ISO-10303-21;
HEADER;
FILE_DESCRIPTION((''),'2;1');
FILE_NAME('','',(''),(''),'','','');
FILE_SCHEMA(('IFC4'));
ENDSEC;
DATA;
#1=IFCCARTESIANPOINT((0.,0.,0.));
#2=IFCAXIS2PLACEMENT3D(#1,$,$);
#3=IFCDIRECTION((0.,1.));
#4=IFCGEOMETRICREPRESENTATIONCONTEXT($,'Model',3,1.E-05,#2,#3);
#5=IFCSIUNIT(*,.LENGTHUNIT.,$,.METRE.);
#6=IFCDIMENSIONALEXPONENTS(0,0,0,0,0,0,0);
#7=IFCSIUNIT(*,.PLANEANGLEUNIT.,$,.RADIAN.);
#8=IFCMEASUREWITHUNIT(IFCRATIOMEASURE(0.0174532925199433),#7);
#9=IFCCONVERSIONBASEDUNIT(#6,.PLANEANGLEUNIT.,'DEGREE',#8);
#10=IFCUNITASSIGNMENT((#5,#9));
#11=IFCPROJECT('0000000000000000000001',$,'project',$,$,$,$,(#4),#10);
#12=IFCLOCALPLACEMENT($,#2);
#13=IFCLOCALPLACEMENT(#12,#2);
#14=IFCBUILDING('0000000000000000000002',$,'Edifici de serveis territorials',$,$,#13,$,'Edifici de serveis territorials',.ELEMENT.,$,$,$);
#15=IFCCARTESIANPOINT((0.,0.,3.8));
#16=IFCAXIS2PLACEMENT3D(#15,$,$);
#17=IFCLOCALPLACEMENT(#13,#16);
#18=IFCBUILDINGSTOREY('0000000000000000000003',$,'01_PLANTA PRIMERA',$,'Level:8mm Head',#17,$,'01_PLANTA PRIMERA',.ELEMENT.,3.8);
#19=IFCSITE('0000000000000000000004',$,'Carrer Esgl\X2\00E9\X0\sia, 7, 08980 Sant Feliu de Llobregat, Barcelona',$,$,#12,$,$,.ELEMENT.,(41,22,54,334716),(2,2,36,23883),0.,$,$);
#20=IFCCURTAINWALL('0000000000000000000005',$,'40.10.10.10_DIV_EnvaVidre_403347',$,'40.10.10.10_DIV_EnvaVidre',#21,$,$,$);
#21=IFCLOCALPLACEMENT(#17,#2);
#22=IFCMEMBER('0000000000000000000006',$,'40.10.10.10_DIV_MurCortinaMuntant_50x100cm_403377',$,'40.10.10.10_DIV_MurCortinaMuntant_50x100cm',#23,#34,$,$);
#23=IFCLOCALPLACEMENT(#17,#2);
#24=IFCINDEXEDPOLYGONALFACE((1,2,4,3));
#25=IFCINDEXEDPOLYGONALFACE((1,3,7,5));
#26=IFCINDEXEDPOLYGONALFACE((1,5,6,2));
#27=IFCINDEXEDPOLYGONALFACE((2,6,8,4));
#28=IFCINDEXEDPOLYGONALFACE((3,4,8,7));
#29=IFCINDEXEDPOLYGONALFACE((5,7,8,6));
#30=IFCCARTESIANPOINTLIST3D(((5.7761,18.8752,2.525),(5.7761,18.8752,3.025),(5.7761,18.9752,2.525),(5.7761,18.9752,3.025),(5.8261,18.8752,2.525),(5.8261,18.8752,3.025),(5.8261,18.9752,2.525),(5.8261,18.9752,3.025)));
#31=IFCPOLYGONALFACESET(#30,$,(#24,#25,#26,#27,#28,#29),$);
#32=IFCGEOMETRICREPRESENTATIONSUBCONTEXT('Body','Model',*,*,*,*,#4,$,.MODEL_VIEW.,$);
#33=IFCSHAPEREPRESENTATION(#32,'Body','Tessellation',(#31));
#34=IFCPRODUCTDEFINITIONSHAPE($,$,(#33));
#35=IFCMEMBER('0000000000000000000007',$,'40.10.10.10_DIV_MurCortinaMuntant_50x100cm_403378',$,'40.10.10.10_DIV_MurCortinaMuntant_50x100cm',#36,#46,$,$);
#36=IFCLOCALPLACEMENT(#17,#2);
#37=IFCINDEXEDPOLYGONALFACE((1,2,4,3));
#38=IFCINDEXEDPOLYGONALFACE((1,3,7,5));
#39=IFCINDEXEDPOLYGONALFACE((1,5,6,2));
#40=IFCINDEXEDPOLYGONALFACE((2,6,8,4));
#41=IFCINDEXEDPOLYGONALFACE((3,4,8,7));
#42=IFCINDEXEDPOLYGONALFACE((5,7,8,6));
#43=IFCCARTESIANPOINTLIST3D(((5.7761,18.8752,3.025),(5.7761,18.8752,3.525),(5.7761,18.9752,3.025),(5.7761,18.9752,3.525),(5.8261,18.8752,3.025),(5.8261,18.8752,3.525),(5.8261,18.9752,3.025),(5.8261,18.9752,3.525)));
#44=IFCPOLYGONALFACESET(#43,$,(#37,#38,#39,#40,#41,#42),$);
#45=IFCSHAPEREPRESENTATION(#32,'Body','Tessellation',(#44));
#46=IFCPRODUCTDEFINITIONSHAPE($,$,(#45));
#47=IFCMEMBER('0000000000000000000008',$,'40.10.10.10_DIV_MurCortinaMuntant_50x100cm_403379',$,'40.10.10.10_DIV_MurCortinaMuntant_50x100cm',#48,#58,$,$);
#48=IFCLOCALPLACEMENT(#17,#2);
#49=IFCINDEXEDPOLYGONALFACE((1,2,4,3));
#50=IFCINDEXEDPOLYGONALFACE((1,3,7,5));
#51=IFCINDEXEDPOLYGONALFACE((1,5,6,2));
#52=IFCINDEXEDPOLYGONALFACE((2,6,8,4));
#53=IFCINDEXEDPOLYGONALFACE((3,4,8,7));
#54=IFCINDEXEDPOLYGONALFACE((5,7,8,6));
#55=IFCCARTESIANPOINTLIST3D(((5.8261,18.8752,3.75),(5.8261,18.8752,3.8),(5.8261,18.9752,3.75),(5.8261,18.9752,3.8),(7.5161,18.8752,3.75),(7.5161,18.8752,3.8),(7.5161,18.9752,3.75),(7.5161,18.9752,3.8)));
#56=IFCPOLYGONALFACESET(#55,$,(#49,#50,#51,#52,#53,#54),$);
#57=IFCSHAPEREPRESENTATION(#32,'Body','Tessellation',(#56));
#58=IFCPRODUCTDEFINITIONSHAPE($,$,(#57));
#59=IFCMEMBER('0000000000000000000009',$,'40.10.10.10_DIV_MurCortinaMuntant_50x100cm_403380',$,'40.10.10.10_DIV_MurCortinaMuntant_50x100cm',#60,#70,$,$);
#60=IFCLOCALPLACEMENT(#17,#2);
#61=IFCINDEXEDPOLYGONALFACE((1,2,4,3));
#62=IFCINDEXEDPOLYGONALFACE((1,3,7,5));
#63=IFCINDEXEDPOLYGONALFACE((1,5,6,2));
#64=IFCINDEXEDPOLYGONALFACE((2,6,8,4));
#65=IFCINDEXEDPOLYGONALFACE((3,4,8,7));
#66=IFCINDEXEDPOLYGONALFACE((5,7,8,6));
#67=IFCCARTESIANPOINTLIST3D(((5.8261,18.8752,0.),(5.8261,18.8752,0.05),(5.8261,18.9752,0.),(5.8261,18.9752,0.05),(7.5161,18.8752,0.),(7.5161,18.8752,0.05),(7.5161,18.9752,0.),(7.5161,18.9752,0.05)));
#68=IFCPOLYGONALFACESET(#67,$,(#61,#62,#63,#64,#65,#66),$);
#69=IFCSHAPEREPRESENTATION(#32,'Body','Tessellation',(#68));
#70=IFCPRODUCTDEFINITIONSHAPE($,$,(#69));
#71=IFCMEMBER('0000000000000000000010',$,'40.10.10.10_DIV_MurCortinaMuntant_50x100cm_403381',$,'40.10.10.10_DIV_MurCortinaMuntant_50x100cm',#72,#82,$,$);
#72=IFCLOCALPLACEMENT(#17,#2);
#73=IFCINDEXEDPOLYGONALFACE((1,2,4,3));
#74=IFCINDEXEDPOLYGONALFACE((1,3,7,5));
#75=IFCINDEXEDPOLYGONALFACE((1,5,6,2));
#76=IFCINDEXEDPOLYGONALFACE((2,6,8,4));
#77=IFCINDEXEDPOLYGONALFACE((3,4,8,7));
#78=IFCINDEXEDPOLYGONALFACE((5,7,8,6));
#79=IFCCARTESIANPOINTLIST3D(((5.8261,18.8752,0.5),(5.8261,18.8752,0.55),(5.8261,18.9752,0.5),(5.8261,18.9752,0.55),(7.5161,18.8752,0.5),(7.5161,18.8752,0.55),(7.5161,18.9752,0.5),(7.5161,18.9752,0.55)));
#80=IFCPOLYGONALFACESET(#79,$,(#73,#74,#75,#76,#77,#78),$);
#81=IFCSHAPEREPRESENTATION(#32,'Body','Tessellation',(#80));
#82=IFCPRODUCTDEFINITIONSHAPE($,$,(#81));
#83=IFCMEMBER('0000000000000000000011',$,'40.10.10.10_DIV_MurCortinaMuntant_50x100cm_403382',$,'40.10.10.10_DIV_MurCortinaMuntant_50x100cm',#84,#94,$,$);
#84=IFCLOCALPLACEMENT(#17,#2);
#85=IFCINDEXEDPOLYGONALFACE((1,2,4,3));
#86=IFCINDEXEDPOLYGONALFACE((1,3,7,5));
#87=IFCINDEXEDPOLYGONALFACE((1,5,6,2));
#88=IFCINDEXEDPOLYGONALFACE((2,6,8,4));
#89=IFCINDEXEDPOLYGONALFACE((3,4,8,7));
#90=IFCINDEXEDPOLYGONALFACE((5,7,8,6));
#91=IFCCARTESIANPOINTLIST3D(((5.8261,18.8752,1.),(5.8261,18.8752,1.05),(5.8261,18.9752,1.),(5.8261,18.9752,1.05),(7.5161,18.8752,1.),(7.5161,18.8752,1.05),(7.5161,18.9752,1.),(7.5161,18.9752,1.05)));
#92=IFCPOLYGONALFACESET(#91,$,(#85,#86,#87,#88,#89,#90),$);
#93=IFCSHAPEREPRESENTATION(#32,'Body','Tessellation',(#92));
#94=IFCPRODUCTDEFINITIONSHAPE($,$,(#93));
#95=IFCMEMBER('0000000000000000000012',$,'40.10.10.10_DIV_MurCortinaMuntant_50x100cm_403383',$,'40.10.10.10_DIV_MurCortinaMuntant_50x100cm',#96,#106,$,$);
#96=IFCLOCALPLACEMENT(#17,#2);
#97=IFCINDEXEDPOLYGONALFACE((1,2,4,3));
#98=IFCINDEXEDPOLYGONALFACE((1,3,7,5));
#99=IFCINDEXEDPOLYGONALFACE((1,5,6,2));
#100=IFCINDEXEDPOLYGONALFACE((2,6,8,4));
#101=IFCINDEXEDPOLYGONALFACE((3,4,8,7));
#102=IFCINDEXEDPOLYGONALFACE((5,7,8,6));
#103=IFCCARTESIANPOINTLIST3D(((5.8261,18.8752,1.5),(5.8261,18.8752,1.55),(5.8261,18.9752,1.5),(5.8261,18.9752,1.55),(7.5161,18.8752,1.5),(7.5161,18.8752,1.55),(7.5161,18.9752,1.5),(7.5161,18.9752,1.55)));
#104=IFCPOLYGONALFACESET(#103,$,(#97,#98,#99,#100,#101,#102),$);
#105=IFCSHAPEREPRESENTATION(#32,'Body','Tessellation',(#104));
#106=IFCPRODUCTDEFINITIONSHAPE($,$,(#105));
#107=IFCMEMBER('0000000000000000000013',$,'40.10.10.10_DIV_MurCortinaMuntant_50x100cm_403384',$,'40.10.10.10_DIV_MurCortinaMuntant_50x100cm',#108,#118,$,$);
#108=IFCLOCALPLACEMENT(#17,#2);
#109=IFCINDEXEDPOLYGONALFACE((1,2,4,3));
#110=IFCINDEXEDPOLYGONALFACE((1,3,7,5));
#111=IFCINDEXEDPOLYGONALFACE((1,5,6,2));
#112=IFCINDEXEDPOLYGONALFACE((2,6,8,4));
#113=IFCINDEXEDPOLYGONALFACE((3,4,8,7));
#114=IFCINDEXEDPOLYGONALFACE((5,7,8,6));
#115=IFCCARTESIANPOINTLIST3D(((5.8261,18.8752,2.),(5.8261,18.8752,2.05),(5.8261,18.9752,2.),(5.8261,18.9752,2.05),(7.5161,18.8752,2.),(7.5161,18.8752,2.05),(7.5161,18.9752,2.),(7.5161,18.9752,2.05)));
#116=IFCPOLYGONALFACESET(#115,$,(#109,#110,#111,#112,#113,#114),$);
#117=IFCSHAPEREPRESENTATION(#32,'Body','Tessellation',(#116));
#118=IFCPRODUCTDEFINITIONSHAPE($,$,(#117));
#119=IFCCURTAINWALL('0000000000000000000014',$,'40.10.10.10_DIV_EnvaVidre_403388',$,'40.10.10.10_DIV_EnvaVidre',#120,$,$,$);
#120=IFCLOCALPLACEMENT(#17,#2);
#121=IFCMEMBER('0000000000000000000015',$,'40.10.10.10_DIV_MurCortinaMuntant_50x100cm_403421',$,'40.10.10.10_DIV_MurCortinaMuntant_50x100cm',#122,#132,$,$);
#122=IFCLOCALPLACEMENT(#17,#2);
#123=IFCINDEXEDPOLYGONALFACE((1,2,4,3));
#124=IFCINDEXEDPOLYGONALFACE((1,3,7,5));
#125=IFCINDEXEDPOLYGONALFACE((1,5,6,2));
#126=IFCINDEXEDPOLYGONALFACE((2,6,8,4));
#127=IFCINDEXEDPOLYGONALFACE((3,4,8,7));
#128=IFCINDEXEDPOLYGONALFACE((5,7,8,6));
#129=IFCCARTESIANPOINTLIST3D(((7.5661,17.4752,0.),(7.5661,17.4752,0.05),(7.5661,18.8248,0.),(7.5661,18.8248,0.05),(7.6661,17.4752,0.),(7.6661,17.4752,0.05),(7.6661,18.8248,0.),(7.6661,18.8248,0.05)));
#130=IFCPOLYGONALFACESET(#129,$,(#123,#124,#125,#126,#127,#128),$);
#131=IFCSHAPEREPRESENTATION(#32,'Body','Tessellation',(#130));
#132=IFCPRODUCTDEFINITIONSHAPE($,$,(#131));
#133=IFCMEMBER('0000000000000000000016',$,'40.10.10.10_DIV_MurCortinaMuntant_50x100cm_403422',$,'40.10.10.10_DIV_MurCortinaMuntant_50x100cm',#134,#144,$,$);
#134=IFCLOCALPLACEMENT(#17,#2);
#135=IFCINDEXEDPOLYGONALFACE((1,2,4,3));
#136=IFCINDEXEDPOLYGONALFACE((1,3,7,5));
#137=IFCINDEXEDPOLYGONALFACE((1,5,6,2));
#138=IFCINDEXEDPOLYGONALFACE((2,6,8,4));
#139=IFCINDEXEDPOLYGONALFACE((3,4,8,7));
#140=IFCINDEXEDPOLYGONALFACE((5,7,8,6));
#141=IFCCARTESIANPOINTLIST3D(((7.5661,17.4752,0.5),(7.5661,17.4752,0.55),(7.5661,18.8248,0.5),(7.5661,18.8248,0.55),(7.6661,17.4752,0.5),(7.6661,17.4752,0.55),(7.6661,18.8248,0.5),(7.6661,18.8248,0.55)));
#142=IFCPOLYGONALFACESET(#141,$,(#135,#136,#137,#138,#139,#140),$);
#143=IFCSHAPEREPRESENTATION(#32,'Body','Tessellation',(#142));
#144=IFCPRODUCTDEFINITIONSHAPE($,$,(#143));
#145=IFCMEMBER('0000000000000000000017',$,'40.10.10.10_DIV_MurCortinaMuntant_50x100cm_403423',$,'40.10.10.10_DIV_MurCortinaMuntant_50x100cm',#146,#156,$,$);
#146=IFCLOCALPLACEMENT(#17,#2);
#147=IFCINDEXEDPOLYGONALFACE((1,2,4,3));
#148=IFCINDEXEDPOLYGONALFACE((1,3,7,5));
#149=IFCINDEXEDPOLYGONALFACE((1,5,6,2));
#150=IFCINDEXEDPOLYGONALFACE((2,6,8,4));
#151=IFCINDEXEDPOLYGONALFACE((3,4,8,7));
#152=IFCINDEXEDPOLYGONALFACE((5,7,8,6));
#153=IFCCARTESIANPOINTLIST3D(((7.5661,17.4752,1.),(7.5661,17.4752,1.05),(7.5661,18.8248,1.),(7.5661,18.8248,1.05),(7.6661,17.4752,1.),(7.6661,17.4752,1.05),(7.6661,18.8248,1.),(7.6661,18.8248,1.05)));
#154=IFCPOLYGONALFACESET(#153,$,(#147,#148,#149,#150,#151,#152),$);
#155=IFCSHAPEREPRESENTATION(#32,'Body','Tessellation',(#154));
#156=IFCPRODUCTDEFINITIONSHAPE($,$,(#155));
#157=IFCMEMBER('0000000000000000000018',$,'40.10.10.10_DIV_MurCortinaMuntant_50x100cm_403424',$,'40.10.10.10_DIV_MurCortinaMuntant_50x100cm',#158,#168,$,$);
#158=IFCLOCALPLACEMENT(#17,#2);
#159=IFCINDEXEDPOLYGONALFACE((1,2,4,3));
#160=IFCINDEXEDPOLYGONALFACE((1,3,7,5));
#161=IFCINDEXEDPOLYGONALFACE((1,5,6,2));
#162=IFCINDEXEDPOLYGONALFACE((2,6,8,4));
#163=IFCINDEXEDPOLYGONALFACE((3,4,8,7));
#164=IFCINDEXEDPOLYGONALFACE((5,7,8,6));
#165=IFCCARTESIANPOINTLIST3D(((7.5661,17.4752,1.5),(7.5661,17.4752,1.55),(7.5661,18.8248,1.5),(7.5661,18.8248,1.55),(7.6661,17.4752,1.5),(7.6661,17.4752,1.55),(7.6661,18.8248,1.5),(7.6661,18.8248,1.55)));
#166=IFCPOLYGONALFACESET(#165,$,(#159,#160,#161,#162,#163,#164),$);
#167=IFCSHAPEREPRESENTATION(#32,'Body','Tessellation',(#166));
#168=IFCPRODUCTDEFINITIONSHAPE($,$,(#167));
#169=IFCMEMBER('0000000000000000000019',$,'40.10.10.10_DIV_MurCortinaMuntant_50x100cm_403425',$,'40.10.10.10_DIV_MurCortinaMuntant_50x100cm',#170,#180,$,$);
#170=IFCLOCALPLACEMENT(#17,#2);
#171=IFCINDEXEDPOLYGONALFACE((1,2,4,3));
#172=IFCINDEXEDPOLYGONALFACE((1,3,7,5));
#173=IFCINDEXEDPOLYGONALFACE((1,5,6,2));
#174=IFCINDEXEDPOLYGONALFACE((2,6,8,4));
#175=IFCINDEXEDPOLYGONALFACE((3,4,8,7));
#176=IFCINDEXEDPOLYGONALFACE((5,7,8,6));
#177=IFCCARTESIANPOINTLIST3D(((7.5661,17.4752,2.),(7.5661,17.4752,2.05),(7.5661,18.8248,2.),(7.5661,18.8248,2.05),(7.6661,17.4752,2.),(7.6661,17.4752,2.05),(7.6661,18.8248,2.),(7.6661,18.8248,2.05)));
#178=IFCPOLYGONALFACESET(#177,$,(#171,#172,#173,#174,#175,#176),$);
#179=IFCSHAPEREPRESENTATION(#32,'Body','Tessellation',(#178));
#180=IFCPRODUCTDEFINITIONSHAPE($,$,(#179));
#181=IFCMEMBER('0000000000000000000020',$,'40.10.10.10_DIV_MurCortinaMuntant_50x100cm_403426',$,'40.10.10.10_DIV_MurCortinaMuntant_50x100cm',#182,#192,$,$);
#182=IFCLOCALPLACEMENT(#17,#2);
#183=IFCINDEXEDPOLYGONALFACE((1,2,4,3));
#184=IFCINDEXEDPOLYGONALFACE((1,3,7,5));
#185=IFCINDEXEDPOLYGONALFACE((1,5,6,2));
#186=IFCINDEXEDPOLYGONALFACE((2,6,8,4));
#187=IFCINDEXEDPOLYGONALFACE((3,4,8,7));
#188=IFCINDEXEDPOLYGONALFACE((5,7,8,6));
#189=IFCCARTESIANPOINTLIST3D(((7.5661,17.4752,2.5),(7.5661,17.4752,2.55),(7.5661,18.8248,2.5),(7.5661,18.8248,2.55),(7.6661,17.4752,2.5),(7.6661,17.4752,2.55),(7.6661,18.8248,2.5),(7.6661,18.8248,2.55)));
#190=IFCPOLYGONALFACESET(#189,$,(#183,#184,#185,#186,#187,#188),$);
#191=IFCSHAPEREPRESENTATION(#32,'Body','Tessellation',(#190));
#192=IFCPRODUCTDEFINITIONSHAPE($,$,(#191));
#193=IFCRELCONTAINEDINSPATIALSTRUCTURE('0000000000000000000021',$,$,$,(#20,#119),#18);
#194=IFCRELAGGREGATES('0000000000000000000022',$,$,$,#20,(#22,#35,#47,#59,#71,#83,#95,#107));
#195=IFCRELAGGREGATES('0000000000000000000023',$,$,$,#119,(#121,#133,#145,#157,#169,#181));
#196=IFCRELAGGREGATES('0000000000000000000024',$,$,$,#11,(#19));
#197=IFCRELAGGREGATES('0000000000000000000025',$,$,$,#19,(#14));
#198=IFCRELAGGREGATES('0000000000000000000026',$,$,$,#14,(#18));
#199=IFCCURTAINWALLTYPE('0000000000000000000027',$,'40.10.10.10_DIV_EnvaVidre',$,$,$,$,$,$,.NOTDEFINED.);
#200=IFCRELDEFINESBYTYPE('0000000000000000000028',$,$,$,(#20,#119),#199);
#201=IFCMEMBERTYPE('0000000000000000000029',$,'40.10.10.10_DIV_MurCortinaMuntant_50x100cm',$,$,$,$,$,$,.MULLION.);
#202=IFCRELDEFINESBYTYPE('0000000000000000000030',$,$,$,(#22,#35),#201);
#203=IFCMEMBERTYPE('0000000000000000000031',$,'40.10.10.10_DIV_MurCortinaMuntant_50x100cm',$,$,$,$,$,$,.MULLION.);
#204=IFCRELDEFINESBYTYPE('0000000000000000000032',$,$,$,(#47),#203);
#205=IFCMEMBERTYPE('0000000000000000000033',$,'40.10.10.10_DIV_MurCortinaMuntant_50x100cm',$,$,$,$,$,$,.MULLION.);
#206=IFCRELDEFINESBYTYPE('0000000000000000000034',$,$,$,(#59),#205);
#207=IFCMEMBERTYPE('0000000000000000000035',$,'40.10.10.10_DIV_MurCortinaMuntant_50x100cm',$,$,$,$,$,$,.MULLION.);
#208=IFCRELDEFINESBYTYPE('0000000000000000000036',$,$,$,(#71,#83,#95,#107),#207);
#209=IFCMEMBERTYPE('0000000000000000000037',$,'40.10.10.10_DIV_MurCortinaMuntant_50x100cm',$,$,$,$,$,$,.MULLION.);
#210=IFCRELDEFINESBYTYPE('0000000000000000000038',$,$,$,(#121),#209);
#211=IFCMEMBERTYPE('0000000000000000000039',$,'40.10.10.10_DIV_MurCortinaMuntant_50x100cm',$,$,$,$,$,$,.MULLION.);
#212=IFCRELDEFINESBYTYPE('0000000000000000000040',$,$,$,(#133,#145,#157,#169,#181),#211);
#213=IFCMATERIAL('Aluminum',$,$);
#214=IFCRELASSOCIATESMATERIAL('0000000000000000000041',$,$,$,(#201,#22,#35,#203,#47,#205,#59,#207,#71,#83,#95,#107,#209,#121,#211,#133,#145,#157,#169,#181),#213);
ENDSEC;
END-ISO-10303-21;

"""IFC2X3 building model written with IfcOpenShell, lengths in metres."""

from ifc_helpers import new_model, entity, si_unit, converted_unit, direction, frame, origin, origin_2d_with_axis, place, context, subcontext, project, spatial, rectangle, extrude, source, transform, mapped, material, type_object, type_shapes, element, aggregate, save


model = new_model("IFC2X3")

# Units and contexts
model_context = context("Model", 3, precision=1e-05, world=origin(), true_north=direction((0.0, 1.0)))
body_context = subcontext(model_context, "Body", "Model", "MODEL_VIEW")
ifc_project = project(units=[si_unit("LENGTHUNIT", "METRE"), converted_unit("PLANEANGLEUNIT", "DEGREE", entity("IfcRatioMeasure", 0.0174532925199433), si_unit("PLANEANGLEUNIT", "RADIAN"), dimensions=[0, 0, 0, 0, 0, 0, 0])], contexts=[model_context])

# Site, building, storey
site_placement = place(None, origin())
site = spatial("IfcSite", under=ifc_project, at=site_placement, Name="Carrer Església, 7, 08980 Sant Feliu de Llobregat, Barcelona", CompositionType="ELEMENT", RefLatitude=(41, 22, 54, 334716), RefLongitude=(2, 2, 36, 23883), RefElevation=0.0)
building_placement = place(site_placement, origin())
building = spatial("IfcBuilding", under=site, at=building_placement, Name="Edifici de serveis territorials", LongName="Edifici de serveis territorials", CompositionType="ELEMENT")
storey_placement = place(building_placement, frame((0.0, 0.0, 3.8)))
storey = spatial("IfcBuildingStorey", under=building, at=storey_placement, Name="01_PLANTA PRIMERA", ObjectType="Level:8mm Head", LongName="01_PLANTA PRIMERA", CompositionType="ELEMENT", Elevation=3.8)

# Curtain wall, members
curtain_wall_type = type_object("IfcCurtainWallType", Name="40.10.10.10_DIV_EnvaVidre", PredefinedType="NOTDEFINED")
curtain_wall_1_placement = place(storey_placement, frame((0.0, 0.0, -3.8)))
curtain_wall_1 = element("IfcCurtainWall", 1, at=curtain_wall_1_placement, inside=storey, type_object=curtain_wall_type, Name="40.10.10.10_DIV_EnvaVidre_403347", ObjectType="40.10.10.10_DIV_EnvaVidre")
ifc_material_1 = material(Name="Aluminum")
member_type_1 = type_object("IfcMemberType", Name="40.10.10.10_DIV_MurCortinaMuntant_50x100cm", PredefinedType="MULLION", material=ifc_material_1)
shared_shape_1 = source(origin(), body_context, "Body", "SweptSolid", [
    extrude(rectangle(XDim=0.1, YDim=0.05, at=origin_2d_with_axis()), frame((-0.025, 0.0, -0.5), z_axis=(0.0, 0.0, 1.0), x_axis=(0.0, -1.0, 0.0)), (0.0, 0.0, 1.0), 0.5),
])
type_shapes(member_type_1, [shared_shape_1])
member_1_placement = place(storey_placement, frame((5.7761, 18.9252, 3.025), z_axis=(0.0, 0.0, 1.0), x_axis=(-1.0, 0.0, 0.0)))
member_1 = element("IfcMember", 2, at=member_1_placement, type_object=member_type_1, material=ifc_material_1, Name="40.10.10.10_DIV_MurCortinaMuntant_50x100cm_403377", ObjectType="40.10.10.10_DIV_MurCortinaMuntant_50x100cm", context=body_context, shape_type="MappedRepresentation", body=[
    mapped(shared_shape_1, transform((0.0, 0.0, 0.0), scale=1.0)),
])
member_2_placement = place(storey_placement, frame((5.7761, 18.9252, 3.525), z_axis=(0.0, 0.0, 1.0), x_axis=(-1.0, 0.0, 0.0)))
member_2 = element("IfcMember", 3, at=member_2_placement, type_object=member_type_1, material=ifc_material_1, Name="40.10.10.10_DIV_MurCortinaMuntant_50x100cm_403378", ObjectType="40.10.10.10_DIV_MurCortinaMuntant_50x100cm", context=body_context, shape_type="MappedRepresentation", body=[
    mapped(shared_shape_1, transform((0.0, 0.0, 0.0), scale=1.0)),
])
member_type_2 = type_object("IfcMemberType", Name="40.10.10.10_DIV_MurCortinaMuntant_50x100cm", PredefinedType="MULLION", material=ifc_material_1)
shared_shape_2 = source(origin(), body_context, "Body", "SweptSolid", [
    extrude(rectangle(XDim=0.1, YDim=0.05, at=origin_2d_with_axis()), frame((-0.025, 0.0, -1.69), z_axis=(0.0, 0.0, 1.0), x_axis=(0.0, -1.0, 0.0)), (0.0, 0.0, 1.0), 1.69),
])
type_shapes(member_type_2, [shared_shape_2])
member_3_placement = place(storey_placement, frame((7.5161, 18.9252, 3.8), z_axis=(1.0, 0.0, 0.0), x_axis=(0.0, 0.0, 1.0)))
member_3 = element("IfcMember", 4, at=member_3_placement, type_object=member_type_2, material=ifc_material_1, Name="40.10.10.10_DIV_MurCortinaMuntant_50x100cm_403379", ObjectType="40.10.10.10_DIV_MurCortinaMuntant_50x100cm", context=body_context, shape_type="MappedRepresentation", body=[
    mapped(shared_shape_2, transform((0.0, 0.0, 0.0), scale=1.0)),
])
member_type_3 = type_object("IfcMemberType", Name="40.10.10.10_DIV_MurCortinaMuntant_50x100cm", PredefinedType="MULLION", material=ifc_material_1)
shared_shape_3 = source(origin(), body_context, "Body", "SweptSolid", [
    extrude(rectangle(XDim=0.1, YDim=0.05, at=origin_2d_with_axis()), frame((-0.025, 0.0, -1.69), z_axis=(0.0, 0.0, 1.0), x_axis=(0.0, -1.0, 0.0)), (0.0, 0.0, 1.0), 1.69),
])
type_shapes(member_type_3, [shared_shape_3])
member_4_placement = place(storey_placement, frame((5.8261, 18.9252, 0.0), z_axis=(-1.0, 0.0, 0.0), x_axis=(0.0, 0.0, -1.0)))
member_4 = element("IfcMember", 5, at=member_4_placement, type_object=member_type_3, material=ifc_material_1, Name="40.10.10.10_DIV_MurCortinaMuntant_50x100cm_403380", ObjectType="40.10.10.10_DIV_MurCortinaMuntant_50x100cm", context=body_context, shape_type="MappedRepresentation", body=[
    mapped(shared_shape_3, transform((0.0, 0.0, 0.0), scale=1.0)),
])
member_type_4 = type_object("IfcMemberType", Name="40.10.10.10_DIV_MurCortinaMuntant_50x100cm", PredefinedType="MULLION", material=ifc_material_1)
shared_shape_4 = source(origin(), body_context, "Body", "SweptSolid", [
    extrude(rectangle(XDim=0.1, YDim=0.05, at=origin_2d_with_axis()), frame((0.0, 0.0, -1.69), z_axis=(0.0, 0.0, 1.0), x_axis=(0.0, -1.0, 0.0)), (0.0, 0.0, 1.0), 1.69),
])
type_shapes(member_type_4, [shared_shape_4])
member_5_placement = place(storey_placement, frame((7.5161, 18.9252, 0.525), z_axis=(1.0, 0.0, 0.0), x_axis=(0.0, 0.0, 1.0)))
member_5 = element("IfcMember", 6, at=member_5_placement, type_object=member_type_4, material=ifc_material_1, Name="40.10.10.10_DIV_MurCortinaMuntant_50x100cm_403381", ObjectType="40.10.10.10_DIV_MurCortinaMuntant_50x100cm", context=body_context, shape_type="MappedRepresentation", body=[
    mapped(shared_shape_4, transform((0.0, 0.0, 0.0), scale=1.0)),
])
member_6_placement = place(storey_placement, frame((7.5161, 18.9252, 1.025), z_axis=(1.0, 0.0, 0.0), x_axis=(0.0, 0.0, 1.0)))
member_6 = element("IfcMember", 7, at=member_6_placement, type_object=member_type_4, material=ifc_material_1, Name="40.10.10.10_DIV_MurCortinaMuntant_50x100cm_403382", ObjectType="40.10.10.10_DIV_MurCortinaMuntant_50x100cm", context=body_context, shape_type="MappedRepresentation", body=[
    mapped(shared_shape_4, transform((0.0, 0.0, 0.0), scale=1.0)),
])
member_7_placement = place(storey_placement, frame((7.5161, 18.9252, 1.525), z_axis=(1.0, 0.0, 0.0), x_axis=(0.0, 0.0, 1.0)))
member_7 = element("IfcMember", 8, at=member_7_placement, type_object=member_type_4, material=ifc_material_1, Name="40.10.10.10_DIV_MurCortinaMuntant_50x100cm_403383", ObjectType="40.10.10.10_DIV_MurCortinaMuntant_50x100cm", context=body_context, shape_type="MappedRepresentation", body=[
    mapped(shared_shape_4, transform((0.0, 0.0, 0.0), scale=1.0)),
])
member_8_placement = place(storey_placement, frame((7.5161, 18.9252, 2.025), z_axis=(1.0, 0.0, 0.0), x_axis=(0.0, 0.0, 1.0)))
member_8 = element("IfcMember", 9, at=member_8_placement, type_object=member_type_4, material=ifc_material_1, Name="40.10.10.10_DIV_MurCortinaMuntant_50x100cm_403384", ObjectType="40.10.10.10_DIV_MurCortinaMuntant_50x100cm", context=body_context, shape_type="MappedRepresentation", body=[
    mapped(shared_shape_4, transform((0.0, 0.0, 0.0), scale=1.0)),
])
aggregate(curtain_wall_1, [member_1, member_2, member_3, member_4, member_5, member_6, member_7, member_8])

# Curtain wall, members
curtain_wall_2_placement = place(storey_placement, frame((0.0, 0.0, -3.8)))
curtain_wall_2 = element("IfcCurtainWall", 10, at=curtain_wall_2_placement, inside=storey, type_object=curtain_wall_type, Name="40.10.10.10_DIV_EnvaVidre_403388", ObjectType="40.10.10.10_DIV_EnvaVidre")
member_type_5 = type_object("IfcMemberType", Name="40.10.10.10_DIV_MurCortinaMuntant_50x100cm", PredefinedType="MULLION", material=ifc_material_1)
shared_shape_5 = source(origin(), body_context, "Body", "SweptSolid", [
    extrude(rectangle(XDim=0.1, YDim=0.05, at=origin_2d_with_axis()), frame((-0.025, 0.0, -1.3496), z_axis=(0.0, 0.0, 1.0), x_axis=(0.0, -1.0, 0.0)), (0.0, 0.0, 1.0), 1.3496),
])
type_shapes(member_type_5, [shared_shape_5])
member_9_placement = place(storey_placement, frame((7.6161, 18.8248, 0.0), z_axis=(0.0, 1.0, 0.0), x_axis=(0.0, 0.0, -1.0)))
member_9 = element("IfcMember", 11, at=member_9_placement, type_object=member_type_5, material=ifc_material_1, Name="40.10.10.10_DIV_MurCortinaMuntant_50x100cm_403421", ObjectType="40.10.10.10_DIV_MurCortinaMuntant_50x100cm", context=body_context, shape_type="MappedRepresentation", body=[
    mapped(shared_shape_5, transform((0.0, 0.0, 0.0), scale=1.0)),
])
member_type_6 = type_object("IfcMemberType", Name="40.10.10.10_DIV_MurCortinaMuntant_50x100cm", PredefinedType="MULLION", material=ifc_material_1)
shared_shape_6 = source(origin(), body_context, "Body", "SweptSolid", [
    extrude(rectangle(XDim=0.1, YDim=0.05, at=origin_2d_with_axis()), frame((0.0, 0.0, -1.3496), z_axis=(0.0, 0.0, 1.0), x_axis=(0.0, -1.0, 0.0)), (0.0, 0.0, 1.0), 1.3496),
])
type_shapes(member_type_6, [shared_shape_6])
member_10_placement = place(storey_placement, frame((7.6161, 17.4752, 0.525), z_axis=(0.0, -1.0, 0.0), x_axis=(0.0, 0.0, 1.0)))
member_10 = element("IfcMember", 12, at=member_10_placement, type_object=member_type_6, material=ifc_material_1, Name="40.10.10.10_DIV_MurCortinaMuntant_50x100cm_403422", ObjectType="40.10.10.10_DIV_MurCortinaMuntant_50x100cm", context=body_context, shape_type="MappedRepresentation", body=[
    mapped(shared_shape_6, transform((0.0, 0.0, 0.0), scale=1.0)),
])
member_11_placement = place(storey_placement, frame((7.6161, 17.4752, 1.025), z_axis=(0.0, -1.0, 0.0), x_axis=(0.0, 0.0, 1.0)))
member_11 = element("IfcMember", 13, at=member_11_placement, type_object=member_type_6, material=ifc_material_1, Name="40.10.10.10_DIV_MurCortinaMuntant_50x100cm_403423", ObjectType="40.10.10.10_DIV_MurCortinaMuntant_50x100cm", context=body_context, shape_type="MappedRepresentation", body=[
    mapped(shared_shape_6, transform((0.0, 0.0, 0.0), scale=1.0)),
])
member_12_placement = place(storey_placement, frame((7.6161, 17.4752, 1.525), z_axis=(0.0, -1.0, 0.0), x_axis=(0.0, 0.0, 1.0)))
member_12 = element("IfcMember", 14, at=member_12_placement, type_object=member_type_6, material=ifc_material_1, Name="40.10.10.10_DIV_MurCortinaMuntant_50x100cm_403424", ObjectType="40.10.10.10_DIV_MurCortinaMuntant_50x100cm", context=body_context, shape_type="MappedRepresentation", body=[
    mapped(shared_shape_6, transform((0.0, 0.0, 0.0), scale=1.0)),
])
member_13_placement = place(storey_placement, frame((7.6161, 17.4752, 2.025), z_axis=(0.0, -1.0, 0.0), x_axis=(0.0, 0.0, 1.0)))
member_13 = element("IfcMember", 15, at=member_13_placement, type_object=member_type_6, material=ifc_material_1, Name="40.10.10.10_DIV_MurCortinaMuntant_50x100cm_403425", ObjectType="40.10.10.10_DIV_MurCortinaMuntant_50x100cm", context=body_context, shape_type="MappedRepresentation", body=[
    mapped(shared_shape_6, transform((0.0, 0.0, 0.0), scale=1.0)),
])
member_14_placement = place(storey_placement, frame((7.6161, 17.4752, 2.525), z_axis=(0.0, -1.0, 0.0), x_axis=(0.0, 0.0, 1.0)))
member_14 = element("IfcMember", 16, at=member_14_placement, type_object=member_type_6, material=ifc_material_1, Name="40.10.10.10_DIV_MurCortinaMuntant_50x100cm_403426", ObjectType="40.10.10.10_DIV_MurCortinaMuntant_50x100cm", context=body_context, shape_type="MappedRepresentation", body=[
    mapped(shared_shape_6, transform((0.0, 0.0, 0.0), scale=1.0)),
])
aggregate(curtain_wall_2, [member_9, member_10, member_11, member_12, member_13, member_14])

save(model, "model.ifc")
